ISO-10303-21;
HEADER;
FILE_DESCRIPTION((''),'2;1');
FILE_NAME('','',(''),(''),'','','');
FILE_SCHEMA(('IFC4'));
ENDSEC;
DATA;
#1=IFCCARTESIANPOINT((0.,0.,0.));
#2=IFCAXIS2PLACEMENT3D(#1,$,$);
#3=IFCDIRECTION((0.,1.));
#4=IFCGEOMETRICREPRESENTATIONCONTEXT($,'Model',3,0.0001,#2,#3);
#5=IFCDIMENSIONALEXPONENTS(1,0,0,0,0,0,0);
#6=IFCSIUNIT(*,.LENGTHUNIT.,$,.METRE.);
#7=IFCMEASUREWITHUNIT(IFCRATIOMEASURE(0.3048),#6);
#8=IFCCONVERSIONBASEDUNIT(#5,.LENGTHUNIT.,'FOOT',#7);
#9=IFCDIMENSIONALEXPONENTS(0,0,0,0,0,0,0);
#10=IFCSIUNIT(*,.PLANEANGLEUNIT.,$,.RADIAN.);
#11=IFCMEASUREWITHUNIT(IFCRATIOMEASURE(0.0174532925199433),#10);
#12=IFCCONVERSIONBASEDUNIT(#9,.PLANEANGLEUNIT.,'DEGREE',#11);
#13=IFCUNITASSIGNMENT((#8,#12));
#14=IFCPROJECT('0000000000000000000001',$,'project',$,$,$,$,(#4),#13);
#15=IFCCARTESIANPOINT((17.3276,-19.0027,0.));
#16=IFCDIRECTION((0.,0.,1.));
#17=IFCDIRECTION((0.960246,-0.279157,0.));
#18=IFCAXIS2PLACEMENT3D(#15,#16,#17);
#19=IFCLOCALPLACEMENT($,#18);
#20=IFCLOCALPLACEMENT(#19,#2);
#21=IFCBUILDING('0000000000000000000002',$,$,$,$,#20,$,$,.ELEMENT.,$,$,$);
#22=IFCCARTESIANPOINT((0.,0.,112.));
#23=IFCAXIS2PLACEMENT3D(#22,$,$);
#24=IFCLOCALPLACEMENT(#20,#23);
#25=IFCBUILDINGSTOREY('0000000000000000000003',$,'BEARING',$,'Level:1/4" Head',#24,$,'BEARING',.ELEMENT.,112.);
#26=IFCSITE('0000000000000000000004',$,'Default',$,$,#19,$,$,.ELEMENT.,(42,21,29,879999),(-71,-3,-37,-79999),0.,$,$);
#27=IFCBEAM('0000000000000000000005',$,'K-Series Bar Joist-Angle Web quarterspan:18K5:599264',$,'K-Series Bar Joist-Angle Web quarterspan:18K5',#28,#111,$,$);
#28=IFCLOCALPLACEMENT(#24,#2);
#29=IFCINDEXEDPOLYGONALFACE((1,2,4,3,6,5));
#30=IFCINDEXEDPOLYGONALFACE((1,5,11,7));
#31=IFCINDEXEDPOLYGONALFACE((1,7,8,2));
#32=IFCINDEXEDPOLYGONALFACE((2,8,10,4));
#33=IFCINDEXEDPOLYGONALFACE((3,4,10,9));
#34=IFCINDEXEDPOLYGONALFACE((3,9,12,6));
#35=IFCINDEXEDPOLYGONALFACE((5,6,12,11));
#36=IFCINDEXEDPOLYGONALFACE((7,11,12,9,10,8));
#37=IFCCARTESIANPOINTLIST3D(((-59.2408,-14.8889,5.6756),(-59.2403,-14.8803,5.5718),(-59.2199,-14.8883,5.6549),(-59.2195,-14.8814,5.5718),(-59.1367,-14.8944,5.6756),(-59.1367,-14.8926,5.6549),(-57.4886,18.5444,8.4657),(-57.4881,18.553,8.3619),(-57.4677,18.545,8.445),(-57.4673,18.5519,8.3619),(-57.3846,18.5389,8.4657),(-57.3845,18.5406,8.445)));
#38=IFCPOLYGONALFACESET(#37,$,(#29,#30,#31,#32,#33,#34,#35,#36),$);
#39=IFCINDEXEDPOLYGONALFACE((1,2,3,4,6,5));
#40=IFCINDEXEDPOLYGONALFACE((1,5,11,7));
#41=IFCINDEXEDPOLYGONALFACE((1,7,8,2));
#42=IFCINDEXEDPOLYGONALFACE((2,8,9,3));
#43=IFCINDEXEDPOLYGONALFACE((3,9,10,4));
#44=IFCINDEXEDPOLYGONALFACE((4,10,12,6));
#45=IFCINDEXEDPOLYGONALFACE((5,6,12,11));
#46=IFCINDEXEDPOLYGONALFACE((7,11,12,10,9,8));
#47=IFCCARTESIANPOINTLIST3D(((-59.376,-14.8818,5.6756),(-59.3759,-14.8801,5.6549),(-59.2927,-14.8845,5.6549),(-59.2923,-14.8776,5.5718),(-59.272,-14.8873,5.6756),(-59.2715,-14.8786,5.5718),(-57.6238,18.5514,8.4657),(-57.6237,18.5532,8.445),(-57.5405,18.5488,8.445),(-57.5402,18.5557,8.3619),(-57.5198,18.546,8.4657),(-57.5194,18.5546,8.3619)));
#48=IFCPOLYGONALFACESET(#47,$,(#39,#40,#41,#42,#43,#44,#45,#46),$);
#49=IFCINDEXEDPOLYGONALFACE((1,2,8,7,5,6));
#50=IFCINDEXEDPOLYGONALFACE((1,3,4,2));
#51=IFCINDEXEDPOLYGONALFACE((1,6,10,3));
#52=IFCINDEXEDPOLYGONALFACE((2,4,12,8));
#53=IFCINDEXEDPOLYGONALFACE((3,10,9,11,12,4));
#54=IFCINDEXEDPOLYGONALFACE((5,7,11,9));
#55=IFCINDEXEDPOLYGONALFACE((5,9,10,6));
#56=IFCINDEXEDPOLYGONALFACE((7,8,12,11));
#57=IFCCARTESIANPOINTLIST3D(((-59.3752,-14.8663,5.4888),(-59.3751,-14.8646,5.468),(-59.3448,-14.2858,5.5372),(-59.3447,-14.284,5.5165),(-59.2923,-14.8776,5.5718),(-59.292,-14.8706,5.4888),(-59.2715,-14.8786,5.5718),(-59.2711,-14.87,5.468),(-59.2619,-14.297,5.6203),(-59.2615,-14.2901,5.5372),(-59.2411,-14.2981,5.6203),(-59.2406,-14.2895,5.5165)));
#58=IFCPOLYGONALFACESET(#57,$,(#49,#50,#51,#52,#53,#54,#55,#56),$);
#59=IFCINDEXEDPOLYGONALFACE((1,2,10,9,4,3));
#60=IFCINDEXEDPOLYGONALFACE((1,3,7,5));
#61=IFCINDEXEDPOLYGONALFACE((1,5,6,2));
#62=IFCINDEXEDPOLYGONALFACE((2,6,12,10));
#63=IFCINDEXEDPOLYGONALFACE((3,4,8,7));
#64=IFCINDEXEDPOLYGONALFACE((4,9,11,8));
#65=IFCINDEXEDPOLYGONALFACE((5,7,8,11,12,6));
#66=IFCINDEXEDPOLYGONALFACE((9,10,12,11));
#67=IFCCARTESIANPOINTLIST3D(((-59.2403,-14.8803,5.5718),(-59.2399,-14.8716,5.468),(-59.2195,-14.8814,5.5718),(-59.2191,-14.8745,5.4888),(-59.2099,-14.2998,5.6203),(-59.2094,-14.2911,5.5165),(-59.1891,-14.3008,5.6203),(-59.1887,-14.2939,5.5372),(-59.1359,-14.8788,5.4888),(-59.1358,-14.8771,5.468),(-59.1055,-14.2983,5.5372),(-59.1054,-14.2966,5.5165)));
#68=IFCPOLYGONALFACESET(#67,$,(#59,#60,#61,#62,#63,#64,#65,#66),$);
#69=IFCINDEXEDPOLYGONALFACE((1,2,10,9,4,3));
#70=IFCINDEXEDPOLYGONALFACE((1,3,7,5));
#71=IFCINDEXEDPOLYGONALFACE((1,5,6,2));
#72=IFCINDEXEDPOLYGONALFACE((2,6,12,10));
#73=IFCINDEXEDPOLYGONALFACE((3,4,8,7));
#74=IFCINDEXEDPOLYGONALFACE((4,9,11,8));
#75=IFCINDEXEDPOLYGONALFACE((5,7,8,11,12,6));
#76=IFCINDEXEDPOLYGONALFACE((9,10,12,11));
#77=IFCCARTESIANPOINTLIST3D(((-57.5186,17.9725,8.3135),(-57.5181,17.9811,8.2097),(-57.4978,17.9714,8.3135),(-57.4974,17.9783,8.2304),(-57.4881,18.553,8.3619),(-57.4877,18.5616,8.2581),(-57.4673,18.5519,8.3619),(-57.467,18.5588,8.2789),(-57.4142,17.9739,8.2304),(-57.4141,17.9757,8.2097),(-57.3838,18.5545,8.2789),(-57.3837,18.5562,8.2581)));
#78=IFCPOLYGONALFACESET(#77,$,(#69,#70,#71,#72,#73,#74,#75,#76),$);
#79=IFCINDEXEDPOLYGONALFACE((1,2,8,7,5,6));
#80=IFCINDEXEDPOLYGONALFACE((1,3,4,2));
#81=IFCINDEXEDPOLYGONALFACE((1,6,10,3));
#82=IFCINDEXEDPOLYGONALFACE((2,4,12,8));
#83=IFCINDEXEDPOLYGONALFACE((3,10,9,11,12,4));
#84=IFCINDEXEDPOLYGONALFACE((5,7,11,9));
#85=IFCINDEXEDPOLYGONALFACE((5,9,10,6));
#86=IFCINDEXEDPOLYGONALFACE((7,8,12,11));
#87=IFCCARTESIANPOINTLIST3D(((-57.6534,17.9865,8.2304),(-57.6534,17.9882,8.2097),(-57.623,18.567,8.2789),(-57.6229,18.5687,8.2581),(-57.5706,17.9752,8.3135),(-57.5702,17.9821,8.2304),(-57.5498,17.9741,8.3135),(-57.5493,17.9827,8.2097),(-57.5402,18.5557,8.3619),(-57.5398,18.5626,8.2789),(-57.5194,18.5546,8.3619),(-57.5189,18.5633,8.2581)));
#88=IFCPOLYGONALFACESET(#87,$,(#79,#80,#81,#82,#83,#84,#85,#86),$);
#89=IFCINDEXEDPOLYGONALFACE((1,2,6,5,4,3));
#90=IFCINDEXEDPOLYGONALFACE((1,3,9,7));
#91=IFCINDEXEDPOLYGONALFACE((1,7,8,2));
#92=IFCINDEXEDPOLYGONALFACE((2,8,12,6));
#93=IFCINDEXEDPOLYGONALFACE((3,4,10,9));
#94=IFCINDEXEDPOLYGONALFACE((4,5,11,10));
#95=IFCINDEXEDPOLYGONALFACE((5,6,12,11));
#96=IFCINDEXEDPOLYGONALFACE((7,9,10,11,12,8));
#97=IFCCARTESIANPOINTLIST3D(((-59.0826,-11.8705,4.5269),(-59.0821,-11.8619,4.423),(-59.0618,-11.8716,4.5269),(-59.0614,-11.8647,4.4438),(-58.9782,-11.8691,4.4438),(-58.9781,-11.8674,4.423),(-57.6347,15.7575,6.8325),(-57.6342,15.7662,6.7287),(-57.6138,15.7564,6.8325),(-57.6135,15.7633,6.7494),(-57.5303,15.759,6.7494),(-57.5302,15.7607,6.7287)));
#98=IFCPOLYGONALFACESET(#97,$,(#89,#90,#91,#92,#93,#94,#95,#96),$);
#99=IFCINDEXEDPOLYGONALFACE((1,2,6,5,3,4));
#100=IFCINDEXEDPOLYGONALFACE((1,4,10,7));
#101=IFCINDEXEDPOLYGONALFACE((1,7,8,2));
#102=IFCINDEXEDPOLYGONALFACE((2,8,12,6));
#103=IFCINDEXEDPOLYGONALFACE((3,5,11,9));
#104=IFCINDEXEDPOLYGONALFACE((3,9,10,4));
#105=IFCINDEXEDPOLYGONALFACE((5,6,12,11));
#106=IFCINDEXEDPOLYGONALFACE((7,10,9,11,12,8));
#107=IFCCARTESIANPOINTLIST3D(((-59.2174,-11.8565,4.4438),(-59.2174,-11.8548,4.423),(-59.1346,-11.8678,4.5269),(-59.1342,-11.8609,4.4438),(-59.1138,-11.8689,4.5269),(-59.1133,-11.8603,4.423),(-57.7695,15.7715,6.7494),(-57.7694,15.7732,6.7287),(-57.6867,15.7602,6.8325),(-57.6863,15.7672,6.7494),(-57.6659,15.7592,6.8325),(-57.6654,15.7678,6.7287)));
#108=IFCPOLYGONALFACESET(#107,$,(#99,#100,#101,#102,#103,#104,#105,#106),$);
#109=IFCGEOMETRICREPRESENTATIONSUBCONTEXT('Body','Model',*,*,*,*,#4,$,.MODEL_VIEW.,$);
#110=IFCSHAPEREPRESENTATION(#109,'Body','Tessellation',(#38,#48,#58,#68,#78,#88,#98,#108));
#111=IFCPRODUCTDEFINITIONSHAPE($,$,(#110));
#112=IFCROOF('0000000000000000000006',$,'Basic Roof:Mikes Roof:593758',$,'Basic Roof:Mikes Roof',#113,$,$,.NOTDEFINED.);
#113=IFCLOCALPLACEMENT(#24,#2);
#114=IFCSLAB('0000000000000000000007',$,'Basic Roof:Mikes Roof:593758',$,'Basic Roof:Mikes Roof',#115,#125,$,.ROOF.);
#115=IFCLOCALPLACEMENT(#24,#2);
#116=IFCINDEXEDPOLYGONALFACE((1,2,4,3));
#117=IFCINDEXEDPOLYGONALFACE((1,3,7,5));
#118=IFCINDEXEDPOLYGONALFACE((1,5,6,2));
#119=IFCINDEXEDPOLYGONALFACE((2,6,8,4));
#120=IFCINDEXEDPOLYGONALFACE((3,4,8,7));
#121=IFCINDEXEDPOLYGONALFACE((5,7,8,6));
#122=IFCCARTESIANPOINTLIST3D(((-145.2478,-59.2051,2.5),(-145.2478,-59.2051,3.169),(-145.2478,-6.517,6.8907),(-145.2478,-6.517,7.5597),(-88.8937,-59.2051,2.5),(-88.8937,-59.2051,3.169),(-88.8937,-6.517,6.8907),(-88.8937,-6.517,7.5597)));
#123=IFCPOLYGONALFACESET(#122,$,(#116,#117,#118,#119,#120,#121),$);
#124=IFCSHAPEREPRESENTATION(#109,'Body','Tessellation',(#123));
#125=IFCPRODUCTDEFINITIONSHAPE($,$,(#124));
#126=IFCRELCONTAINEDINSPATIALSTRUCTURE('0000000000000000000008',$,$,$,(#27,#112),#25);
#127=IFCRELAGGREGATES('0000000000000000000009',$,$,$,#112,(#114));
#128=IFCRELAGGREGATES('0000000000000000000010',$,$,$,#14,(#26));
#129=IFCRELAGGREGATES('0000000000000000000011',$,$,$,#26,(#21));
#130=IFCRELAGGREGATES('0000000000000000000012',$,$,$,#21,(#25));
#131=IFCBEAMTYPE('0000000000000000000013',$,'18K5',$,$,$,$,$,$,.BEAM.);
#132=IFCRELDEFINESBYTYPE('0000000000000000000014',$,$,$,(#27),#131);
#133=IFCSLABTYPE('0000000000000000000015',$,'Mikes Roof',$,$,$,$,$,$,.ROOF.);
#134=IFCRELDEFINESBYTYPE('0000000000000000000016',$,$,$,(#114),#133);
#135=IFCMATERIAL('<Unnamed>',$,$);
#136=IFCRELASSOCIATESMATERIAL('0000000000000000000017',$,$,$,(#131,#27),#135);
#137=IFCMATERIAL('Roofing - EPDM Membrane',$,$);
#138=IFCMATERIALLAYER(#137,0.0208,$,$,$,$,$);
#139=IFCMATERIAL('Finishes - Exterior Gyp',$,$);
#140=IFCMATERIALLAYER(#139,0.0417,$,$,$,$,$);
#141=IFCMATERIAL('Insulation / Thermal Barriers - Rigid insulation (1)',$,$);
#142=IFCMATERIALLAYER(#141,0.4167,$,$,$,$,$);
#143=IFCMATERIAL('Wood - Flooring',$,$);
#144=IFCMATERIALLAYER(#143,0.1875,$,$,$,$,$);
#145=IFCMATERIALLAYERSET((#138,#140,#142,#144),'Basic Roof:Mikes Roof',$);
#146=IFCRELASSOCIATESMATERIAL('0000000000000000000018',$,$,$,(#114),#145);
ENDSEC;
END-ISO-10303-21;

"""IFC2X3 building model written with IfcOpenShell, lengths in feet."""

from ifc_helpers import new_model, entity, si_unit, converted_unit, direction, frame, frame_2d, origin, place, context, subcontext, project, spatial, polyline, rectangle, outline, extrude, source, transform, mapped, material, layer, layer_set, type_object, type_shapes, element, aggregate, save


model = new_model("IFC2X3")

# Units and contexts
model_context = context("Model", 3, precision=0.0001, world=origin(), true_north=direction((0.0, 1.0)))
body_context = subcontext(model_context, "Body", "Model", "MODEL_VIEW")
ifc_project = project(units=[converted_unit("LENGTHUNIT", "FOOT", entity("IfcRatioMeasure", 0.3048), si_unit("LENGTHUNIT", "METRE"), dimensions=[1, 0, 0, 0, 0, 0, 0]), converted_unit("PLANEANGLEUNIT", "DEGREE", entity("IfcRatioMeasure", 0.0174532925199433), si_unit("PLANEANGLEUNIT", "RADIAN"), dimensions=[0, 0, 0, 0, 0, 0, 0])], contexts=[model_context])

# Site, building, storey
site_placement = place(None, frame((17.3276, -19.0027, 0.0), z_axis=(0.0, 0.0, 1.0), x_axis=(0.960246, -0.279157, 0.0)))
site = spatial("IfcSite", under=ifc_project, at=site_placement, Name="Default", CompositionType="ELEMENT", RefLatitude=(42, 21, 29, 879999), RefLongitude=(-71, -3, -37, -79999), RefElevation=0.0)
building_placement = place(site_placement, origin())
building = spatial("IfcBuilding", under=site, at=building_placement, CompositionType="ELEMENT")
storey_placement = place(building_placement, frame((0.0, 0.0, 112.0)))
storey = spatial("IfcBuildingStorey", under=building, at=storey_placement, Name="BEARING", ObjectType="Level:1/4\" Head", LongName="BEARING", CompositionType="ELEMENT", Elevation=112.0)

# Shared definitions
ifc_material_1 = material(Name="<Unnamed>")

# Beam
beam_type_1 = type_object("IfcBeamType", Name="18K5", PredefinedType="BEAM", material=ifc_material_1)
shared_shape_1 = source(origin(), body_context, "Body", "SweptSolid", [
    extrude(outline(polyline([(-0.0417, -0.0625), (-0.0208, -0.0625), (-0.0208, 0.0208), (0.0625, 0.0208), (0.0625, 0.0417), (-0.0417, 0.0417), (-0.0417, -0.0625)])), frame((-16.7976, -0.0573, 0.7083), z_axis=(1.0, 0.0, 0.0), x_axis=(0.0, 0.0, -1.0)), (0.0, 0.0, 1.0), 33.5952),
    extrude(outline(polyline([(-0.0417, -0.0417), (0.0625, -0.0417), (0.0625, -0.0208), (-0.0208, -0.0208), (-0.0208, 0.0625), (-0.0417, 0.0625), (-0.0417, -0.0417)])), frame((-16.7976, 0.0573, 0.7083), z_axis=(1.0, 0.0, 0.0), x_axis=(0.0, 0.0, -1.0)), (0.0, 0.0, 1.0), 33.5952),
    extrude(outline(polyline([(-0.0625, -0.0417), (0.0417, -0.0417), (0.0417, 0.0625), (0.0208, 0.0625), (0.0208, -0.0208), (-0.0625, -0.0208), (-0.0625, -0.0417)])), frame((-16.7976, 0.0573, 0.5833), z_axis=(1.0, 0.0, 0.0), x_axis=(0.0, 0.0, -1.0)), (0.0, 0.0, 1.0), 0.5833),
    extrude(outline(polyline([(0.0208, -0.0625), (0.0417, -0.0625), (0.0417, 0.0417), (-0.0625, 0.0417), (-0.0625, 0.0208), (0.0208, 0.0208), (0.0208, -0.0625)])), frame((-16.7976, -0.0573, 0.5833), z_axis=(1.0, 0.0, 0.0), x_axis=(0.0, 0.0, -1.0)), (0.0, 0.0, 1.0), 0.5833),
    extrude(outline(polyline([(0.0208, -0.0625), (0.0417, -0.0625), (0.0417, 0.0417), (-0.0625, 0.0417), (-0.0625, 0.0208), (0.0208, 0.0208), (0.0208, -0.0625)])), frame((16.2143, -0.0573, 0.5833), z_axis=(1.0, 0.0, 0.0), x_axis=(0.0, 0.0, -1.0)), (0.0, 0.0, 1.0), 0.5833),
    extrude(outline(polyline([(-0.0625, -0.0417), (0.0417, -0.0417), (0.0417, 0.0625), (0.0208, 0.0625), (0.0208, -0.0208), (-0.0625, -0.0208), (-0.0625, -0.0417)])), frame((16.2143, 0.0573, 0.5833), z_axis=(1.0, 0.0, 0.0), x_axis=(0.0, 0.0, -1.0)), (0.0, 0.0, 1.0), 0.5833),
    extrude(outline(polyline([(0.0208, -0.0625), (0.0417, -0.0625), (0.0417, 0.0417), (-0.0625, 0.0417), (-0.0625, 0.0208), (0.0208, 0.0208), (0.0208, -0.0625)])), frame((-13.8809, -0.0573, -0.7083), z_axis=(1.0, 0.0, 0.0), x_axis=(0.0, 0.0, -1.0)), (0.0, 0.0, 1.0), 27.7619),
    extrude(outline(polyline([(-0.0625, -0.0417), (0.0417, -0.0417), (0.0417, 0.0625), (0.0208, 0.0625), (0.0208, -0.0208), (-0.0625, -0.0208), (-0.0625, -0.0417)])), frame((-13.8809, 0.0573, -0.7083), z_axis=(1.0, 0.0, 0.0), x_axis=(0.0, 0.0, -1.0)), (0.0, 0.0, 1.0), 27.7619),
])
type_shapes(beam_type_1, [shared_shape_1])
beam_1_placement = place(storey_placement, frame((-58.377, 1.8907, 6.3233), z_axis=(-0.004347, -0.082936, 0.996545), x_axis=(0.052155, 0.99518, 0.08305)))
element("IfcBeam", 1, at=beam_1_placement, inside=storey, type_object=beam_type_1, material=ifc_material_1, Name="K-Series Bar Joist-Angle Web quarterspan:18K5:599264", ObjectType="K-Series Bar Joist-Angle Web quarterspan:18K5", context=body_context, shape_type="MappedRepresentation", body=[
    mapped(shared_shape_1, transform((0.0, 0.0, 0.0), scale=1.0)),
])

# Roof, slab
roof_placement = place(storey_placement, frame((-145.2478, -59.2051, 2.5)))
roof = element("IfcRoof", 2, at=roof_placement, inside=storey, Name="Basic Roof:Mikes Roof:593758", ObjectType="Basic Roof:Mikes Roof", ShapeType="NOTDEFINED")
ifc_material_2 = material(Name="Roofing - EPDM Membrane")
ifc_layer_1 = layer(ifc_material_2, 0.0208)
ifc_material_3 = material(Name="Finishes - Exterior Gyp")
ifc_layer_2 = layer(ifc_material_3, 0.0417)
ifc_material_4 = material(Name="Insulation / Thermal Barriers - Rigid insulation (1)")
ifc_layer_3 = layer(ifc_material_4, 0.4167)
ifc_material_5 = material(Name="Wood - Flooring")
ifc_layer_4 = layer(ifc_material_5, 0.1875)
ifc_layer_set = layer_set([ifc_layer_1, ifc_layer_2, ifc_layer_3, ifc_layer_4], Name="Basic Roof:Mikes Roof")
slab_type = type_object("IfcSlabType", Name="Mikes Roof", PredefinedType="ROOF")
slab_placement = place(roof_placement, origin())
slab = element("IfcSlab", 3, at=slab_placement, type_object=slab_type, material=ifc_layer_set, Name="Basic Roof:Mikes Roof:593758", ObjectType="Basic Roof:Mikes Roof", PredefinedType="ROOF", context=body_context, shape_type="SweptSolid", body=[
    extrude(rectangle(XDim=52.8707, YDim=56.3542, at=frame_2d((0.0, 0.0), x_axis=(0.0, -1.0))), frame((28.1771, 26.3441, 2.1953), z_axis=(0.0, -0.083045, 0.996546), x_axis=(1.0, 0.0, 0.0)), (0.0, 0.083045, 0.996546), 0.669),
])
aggregate(roof, [slab])

save(model, "model.ifc")
